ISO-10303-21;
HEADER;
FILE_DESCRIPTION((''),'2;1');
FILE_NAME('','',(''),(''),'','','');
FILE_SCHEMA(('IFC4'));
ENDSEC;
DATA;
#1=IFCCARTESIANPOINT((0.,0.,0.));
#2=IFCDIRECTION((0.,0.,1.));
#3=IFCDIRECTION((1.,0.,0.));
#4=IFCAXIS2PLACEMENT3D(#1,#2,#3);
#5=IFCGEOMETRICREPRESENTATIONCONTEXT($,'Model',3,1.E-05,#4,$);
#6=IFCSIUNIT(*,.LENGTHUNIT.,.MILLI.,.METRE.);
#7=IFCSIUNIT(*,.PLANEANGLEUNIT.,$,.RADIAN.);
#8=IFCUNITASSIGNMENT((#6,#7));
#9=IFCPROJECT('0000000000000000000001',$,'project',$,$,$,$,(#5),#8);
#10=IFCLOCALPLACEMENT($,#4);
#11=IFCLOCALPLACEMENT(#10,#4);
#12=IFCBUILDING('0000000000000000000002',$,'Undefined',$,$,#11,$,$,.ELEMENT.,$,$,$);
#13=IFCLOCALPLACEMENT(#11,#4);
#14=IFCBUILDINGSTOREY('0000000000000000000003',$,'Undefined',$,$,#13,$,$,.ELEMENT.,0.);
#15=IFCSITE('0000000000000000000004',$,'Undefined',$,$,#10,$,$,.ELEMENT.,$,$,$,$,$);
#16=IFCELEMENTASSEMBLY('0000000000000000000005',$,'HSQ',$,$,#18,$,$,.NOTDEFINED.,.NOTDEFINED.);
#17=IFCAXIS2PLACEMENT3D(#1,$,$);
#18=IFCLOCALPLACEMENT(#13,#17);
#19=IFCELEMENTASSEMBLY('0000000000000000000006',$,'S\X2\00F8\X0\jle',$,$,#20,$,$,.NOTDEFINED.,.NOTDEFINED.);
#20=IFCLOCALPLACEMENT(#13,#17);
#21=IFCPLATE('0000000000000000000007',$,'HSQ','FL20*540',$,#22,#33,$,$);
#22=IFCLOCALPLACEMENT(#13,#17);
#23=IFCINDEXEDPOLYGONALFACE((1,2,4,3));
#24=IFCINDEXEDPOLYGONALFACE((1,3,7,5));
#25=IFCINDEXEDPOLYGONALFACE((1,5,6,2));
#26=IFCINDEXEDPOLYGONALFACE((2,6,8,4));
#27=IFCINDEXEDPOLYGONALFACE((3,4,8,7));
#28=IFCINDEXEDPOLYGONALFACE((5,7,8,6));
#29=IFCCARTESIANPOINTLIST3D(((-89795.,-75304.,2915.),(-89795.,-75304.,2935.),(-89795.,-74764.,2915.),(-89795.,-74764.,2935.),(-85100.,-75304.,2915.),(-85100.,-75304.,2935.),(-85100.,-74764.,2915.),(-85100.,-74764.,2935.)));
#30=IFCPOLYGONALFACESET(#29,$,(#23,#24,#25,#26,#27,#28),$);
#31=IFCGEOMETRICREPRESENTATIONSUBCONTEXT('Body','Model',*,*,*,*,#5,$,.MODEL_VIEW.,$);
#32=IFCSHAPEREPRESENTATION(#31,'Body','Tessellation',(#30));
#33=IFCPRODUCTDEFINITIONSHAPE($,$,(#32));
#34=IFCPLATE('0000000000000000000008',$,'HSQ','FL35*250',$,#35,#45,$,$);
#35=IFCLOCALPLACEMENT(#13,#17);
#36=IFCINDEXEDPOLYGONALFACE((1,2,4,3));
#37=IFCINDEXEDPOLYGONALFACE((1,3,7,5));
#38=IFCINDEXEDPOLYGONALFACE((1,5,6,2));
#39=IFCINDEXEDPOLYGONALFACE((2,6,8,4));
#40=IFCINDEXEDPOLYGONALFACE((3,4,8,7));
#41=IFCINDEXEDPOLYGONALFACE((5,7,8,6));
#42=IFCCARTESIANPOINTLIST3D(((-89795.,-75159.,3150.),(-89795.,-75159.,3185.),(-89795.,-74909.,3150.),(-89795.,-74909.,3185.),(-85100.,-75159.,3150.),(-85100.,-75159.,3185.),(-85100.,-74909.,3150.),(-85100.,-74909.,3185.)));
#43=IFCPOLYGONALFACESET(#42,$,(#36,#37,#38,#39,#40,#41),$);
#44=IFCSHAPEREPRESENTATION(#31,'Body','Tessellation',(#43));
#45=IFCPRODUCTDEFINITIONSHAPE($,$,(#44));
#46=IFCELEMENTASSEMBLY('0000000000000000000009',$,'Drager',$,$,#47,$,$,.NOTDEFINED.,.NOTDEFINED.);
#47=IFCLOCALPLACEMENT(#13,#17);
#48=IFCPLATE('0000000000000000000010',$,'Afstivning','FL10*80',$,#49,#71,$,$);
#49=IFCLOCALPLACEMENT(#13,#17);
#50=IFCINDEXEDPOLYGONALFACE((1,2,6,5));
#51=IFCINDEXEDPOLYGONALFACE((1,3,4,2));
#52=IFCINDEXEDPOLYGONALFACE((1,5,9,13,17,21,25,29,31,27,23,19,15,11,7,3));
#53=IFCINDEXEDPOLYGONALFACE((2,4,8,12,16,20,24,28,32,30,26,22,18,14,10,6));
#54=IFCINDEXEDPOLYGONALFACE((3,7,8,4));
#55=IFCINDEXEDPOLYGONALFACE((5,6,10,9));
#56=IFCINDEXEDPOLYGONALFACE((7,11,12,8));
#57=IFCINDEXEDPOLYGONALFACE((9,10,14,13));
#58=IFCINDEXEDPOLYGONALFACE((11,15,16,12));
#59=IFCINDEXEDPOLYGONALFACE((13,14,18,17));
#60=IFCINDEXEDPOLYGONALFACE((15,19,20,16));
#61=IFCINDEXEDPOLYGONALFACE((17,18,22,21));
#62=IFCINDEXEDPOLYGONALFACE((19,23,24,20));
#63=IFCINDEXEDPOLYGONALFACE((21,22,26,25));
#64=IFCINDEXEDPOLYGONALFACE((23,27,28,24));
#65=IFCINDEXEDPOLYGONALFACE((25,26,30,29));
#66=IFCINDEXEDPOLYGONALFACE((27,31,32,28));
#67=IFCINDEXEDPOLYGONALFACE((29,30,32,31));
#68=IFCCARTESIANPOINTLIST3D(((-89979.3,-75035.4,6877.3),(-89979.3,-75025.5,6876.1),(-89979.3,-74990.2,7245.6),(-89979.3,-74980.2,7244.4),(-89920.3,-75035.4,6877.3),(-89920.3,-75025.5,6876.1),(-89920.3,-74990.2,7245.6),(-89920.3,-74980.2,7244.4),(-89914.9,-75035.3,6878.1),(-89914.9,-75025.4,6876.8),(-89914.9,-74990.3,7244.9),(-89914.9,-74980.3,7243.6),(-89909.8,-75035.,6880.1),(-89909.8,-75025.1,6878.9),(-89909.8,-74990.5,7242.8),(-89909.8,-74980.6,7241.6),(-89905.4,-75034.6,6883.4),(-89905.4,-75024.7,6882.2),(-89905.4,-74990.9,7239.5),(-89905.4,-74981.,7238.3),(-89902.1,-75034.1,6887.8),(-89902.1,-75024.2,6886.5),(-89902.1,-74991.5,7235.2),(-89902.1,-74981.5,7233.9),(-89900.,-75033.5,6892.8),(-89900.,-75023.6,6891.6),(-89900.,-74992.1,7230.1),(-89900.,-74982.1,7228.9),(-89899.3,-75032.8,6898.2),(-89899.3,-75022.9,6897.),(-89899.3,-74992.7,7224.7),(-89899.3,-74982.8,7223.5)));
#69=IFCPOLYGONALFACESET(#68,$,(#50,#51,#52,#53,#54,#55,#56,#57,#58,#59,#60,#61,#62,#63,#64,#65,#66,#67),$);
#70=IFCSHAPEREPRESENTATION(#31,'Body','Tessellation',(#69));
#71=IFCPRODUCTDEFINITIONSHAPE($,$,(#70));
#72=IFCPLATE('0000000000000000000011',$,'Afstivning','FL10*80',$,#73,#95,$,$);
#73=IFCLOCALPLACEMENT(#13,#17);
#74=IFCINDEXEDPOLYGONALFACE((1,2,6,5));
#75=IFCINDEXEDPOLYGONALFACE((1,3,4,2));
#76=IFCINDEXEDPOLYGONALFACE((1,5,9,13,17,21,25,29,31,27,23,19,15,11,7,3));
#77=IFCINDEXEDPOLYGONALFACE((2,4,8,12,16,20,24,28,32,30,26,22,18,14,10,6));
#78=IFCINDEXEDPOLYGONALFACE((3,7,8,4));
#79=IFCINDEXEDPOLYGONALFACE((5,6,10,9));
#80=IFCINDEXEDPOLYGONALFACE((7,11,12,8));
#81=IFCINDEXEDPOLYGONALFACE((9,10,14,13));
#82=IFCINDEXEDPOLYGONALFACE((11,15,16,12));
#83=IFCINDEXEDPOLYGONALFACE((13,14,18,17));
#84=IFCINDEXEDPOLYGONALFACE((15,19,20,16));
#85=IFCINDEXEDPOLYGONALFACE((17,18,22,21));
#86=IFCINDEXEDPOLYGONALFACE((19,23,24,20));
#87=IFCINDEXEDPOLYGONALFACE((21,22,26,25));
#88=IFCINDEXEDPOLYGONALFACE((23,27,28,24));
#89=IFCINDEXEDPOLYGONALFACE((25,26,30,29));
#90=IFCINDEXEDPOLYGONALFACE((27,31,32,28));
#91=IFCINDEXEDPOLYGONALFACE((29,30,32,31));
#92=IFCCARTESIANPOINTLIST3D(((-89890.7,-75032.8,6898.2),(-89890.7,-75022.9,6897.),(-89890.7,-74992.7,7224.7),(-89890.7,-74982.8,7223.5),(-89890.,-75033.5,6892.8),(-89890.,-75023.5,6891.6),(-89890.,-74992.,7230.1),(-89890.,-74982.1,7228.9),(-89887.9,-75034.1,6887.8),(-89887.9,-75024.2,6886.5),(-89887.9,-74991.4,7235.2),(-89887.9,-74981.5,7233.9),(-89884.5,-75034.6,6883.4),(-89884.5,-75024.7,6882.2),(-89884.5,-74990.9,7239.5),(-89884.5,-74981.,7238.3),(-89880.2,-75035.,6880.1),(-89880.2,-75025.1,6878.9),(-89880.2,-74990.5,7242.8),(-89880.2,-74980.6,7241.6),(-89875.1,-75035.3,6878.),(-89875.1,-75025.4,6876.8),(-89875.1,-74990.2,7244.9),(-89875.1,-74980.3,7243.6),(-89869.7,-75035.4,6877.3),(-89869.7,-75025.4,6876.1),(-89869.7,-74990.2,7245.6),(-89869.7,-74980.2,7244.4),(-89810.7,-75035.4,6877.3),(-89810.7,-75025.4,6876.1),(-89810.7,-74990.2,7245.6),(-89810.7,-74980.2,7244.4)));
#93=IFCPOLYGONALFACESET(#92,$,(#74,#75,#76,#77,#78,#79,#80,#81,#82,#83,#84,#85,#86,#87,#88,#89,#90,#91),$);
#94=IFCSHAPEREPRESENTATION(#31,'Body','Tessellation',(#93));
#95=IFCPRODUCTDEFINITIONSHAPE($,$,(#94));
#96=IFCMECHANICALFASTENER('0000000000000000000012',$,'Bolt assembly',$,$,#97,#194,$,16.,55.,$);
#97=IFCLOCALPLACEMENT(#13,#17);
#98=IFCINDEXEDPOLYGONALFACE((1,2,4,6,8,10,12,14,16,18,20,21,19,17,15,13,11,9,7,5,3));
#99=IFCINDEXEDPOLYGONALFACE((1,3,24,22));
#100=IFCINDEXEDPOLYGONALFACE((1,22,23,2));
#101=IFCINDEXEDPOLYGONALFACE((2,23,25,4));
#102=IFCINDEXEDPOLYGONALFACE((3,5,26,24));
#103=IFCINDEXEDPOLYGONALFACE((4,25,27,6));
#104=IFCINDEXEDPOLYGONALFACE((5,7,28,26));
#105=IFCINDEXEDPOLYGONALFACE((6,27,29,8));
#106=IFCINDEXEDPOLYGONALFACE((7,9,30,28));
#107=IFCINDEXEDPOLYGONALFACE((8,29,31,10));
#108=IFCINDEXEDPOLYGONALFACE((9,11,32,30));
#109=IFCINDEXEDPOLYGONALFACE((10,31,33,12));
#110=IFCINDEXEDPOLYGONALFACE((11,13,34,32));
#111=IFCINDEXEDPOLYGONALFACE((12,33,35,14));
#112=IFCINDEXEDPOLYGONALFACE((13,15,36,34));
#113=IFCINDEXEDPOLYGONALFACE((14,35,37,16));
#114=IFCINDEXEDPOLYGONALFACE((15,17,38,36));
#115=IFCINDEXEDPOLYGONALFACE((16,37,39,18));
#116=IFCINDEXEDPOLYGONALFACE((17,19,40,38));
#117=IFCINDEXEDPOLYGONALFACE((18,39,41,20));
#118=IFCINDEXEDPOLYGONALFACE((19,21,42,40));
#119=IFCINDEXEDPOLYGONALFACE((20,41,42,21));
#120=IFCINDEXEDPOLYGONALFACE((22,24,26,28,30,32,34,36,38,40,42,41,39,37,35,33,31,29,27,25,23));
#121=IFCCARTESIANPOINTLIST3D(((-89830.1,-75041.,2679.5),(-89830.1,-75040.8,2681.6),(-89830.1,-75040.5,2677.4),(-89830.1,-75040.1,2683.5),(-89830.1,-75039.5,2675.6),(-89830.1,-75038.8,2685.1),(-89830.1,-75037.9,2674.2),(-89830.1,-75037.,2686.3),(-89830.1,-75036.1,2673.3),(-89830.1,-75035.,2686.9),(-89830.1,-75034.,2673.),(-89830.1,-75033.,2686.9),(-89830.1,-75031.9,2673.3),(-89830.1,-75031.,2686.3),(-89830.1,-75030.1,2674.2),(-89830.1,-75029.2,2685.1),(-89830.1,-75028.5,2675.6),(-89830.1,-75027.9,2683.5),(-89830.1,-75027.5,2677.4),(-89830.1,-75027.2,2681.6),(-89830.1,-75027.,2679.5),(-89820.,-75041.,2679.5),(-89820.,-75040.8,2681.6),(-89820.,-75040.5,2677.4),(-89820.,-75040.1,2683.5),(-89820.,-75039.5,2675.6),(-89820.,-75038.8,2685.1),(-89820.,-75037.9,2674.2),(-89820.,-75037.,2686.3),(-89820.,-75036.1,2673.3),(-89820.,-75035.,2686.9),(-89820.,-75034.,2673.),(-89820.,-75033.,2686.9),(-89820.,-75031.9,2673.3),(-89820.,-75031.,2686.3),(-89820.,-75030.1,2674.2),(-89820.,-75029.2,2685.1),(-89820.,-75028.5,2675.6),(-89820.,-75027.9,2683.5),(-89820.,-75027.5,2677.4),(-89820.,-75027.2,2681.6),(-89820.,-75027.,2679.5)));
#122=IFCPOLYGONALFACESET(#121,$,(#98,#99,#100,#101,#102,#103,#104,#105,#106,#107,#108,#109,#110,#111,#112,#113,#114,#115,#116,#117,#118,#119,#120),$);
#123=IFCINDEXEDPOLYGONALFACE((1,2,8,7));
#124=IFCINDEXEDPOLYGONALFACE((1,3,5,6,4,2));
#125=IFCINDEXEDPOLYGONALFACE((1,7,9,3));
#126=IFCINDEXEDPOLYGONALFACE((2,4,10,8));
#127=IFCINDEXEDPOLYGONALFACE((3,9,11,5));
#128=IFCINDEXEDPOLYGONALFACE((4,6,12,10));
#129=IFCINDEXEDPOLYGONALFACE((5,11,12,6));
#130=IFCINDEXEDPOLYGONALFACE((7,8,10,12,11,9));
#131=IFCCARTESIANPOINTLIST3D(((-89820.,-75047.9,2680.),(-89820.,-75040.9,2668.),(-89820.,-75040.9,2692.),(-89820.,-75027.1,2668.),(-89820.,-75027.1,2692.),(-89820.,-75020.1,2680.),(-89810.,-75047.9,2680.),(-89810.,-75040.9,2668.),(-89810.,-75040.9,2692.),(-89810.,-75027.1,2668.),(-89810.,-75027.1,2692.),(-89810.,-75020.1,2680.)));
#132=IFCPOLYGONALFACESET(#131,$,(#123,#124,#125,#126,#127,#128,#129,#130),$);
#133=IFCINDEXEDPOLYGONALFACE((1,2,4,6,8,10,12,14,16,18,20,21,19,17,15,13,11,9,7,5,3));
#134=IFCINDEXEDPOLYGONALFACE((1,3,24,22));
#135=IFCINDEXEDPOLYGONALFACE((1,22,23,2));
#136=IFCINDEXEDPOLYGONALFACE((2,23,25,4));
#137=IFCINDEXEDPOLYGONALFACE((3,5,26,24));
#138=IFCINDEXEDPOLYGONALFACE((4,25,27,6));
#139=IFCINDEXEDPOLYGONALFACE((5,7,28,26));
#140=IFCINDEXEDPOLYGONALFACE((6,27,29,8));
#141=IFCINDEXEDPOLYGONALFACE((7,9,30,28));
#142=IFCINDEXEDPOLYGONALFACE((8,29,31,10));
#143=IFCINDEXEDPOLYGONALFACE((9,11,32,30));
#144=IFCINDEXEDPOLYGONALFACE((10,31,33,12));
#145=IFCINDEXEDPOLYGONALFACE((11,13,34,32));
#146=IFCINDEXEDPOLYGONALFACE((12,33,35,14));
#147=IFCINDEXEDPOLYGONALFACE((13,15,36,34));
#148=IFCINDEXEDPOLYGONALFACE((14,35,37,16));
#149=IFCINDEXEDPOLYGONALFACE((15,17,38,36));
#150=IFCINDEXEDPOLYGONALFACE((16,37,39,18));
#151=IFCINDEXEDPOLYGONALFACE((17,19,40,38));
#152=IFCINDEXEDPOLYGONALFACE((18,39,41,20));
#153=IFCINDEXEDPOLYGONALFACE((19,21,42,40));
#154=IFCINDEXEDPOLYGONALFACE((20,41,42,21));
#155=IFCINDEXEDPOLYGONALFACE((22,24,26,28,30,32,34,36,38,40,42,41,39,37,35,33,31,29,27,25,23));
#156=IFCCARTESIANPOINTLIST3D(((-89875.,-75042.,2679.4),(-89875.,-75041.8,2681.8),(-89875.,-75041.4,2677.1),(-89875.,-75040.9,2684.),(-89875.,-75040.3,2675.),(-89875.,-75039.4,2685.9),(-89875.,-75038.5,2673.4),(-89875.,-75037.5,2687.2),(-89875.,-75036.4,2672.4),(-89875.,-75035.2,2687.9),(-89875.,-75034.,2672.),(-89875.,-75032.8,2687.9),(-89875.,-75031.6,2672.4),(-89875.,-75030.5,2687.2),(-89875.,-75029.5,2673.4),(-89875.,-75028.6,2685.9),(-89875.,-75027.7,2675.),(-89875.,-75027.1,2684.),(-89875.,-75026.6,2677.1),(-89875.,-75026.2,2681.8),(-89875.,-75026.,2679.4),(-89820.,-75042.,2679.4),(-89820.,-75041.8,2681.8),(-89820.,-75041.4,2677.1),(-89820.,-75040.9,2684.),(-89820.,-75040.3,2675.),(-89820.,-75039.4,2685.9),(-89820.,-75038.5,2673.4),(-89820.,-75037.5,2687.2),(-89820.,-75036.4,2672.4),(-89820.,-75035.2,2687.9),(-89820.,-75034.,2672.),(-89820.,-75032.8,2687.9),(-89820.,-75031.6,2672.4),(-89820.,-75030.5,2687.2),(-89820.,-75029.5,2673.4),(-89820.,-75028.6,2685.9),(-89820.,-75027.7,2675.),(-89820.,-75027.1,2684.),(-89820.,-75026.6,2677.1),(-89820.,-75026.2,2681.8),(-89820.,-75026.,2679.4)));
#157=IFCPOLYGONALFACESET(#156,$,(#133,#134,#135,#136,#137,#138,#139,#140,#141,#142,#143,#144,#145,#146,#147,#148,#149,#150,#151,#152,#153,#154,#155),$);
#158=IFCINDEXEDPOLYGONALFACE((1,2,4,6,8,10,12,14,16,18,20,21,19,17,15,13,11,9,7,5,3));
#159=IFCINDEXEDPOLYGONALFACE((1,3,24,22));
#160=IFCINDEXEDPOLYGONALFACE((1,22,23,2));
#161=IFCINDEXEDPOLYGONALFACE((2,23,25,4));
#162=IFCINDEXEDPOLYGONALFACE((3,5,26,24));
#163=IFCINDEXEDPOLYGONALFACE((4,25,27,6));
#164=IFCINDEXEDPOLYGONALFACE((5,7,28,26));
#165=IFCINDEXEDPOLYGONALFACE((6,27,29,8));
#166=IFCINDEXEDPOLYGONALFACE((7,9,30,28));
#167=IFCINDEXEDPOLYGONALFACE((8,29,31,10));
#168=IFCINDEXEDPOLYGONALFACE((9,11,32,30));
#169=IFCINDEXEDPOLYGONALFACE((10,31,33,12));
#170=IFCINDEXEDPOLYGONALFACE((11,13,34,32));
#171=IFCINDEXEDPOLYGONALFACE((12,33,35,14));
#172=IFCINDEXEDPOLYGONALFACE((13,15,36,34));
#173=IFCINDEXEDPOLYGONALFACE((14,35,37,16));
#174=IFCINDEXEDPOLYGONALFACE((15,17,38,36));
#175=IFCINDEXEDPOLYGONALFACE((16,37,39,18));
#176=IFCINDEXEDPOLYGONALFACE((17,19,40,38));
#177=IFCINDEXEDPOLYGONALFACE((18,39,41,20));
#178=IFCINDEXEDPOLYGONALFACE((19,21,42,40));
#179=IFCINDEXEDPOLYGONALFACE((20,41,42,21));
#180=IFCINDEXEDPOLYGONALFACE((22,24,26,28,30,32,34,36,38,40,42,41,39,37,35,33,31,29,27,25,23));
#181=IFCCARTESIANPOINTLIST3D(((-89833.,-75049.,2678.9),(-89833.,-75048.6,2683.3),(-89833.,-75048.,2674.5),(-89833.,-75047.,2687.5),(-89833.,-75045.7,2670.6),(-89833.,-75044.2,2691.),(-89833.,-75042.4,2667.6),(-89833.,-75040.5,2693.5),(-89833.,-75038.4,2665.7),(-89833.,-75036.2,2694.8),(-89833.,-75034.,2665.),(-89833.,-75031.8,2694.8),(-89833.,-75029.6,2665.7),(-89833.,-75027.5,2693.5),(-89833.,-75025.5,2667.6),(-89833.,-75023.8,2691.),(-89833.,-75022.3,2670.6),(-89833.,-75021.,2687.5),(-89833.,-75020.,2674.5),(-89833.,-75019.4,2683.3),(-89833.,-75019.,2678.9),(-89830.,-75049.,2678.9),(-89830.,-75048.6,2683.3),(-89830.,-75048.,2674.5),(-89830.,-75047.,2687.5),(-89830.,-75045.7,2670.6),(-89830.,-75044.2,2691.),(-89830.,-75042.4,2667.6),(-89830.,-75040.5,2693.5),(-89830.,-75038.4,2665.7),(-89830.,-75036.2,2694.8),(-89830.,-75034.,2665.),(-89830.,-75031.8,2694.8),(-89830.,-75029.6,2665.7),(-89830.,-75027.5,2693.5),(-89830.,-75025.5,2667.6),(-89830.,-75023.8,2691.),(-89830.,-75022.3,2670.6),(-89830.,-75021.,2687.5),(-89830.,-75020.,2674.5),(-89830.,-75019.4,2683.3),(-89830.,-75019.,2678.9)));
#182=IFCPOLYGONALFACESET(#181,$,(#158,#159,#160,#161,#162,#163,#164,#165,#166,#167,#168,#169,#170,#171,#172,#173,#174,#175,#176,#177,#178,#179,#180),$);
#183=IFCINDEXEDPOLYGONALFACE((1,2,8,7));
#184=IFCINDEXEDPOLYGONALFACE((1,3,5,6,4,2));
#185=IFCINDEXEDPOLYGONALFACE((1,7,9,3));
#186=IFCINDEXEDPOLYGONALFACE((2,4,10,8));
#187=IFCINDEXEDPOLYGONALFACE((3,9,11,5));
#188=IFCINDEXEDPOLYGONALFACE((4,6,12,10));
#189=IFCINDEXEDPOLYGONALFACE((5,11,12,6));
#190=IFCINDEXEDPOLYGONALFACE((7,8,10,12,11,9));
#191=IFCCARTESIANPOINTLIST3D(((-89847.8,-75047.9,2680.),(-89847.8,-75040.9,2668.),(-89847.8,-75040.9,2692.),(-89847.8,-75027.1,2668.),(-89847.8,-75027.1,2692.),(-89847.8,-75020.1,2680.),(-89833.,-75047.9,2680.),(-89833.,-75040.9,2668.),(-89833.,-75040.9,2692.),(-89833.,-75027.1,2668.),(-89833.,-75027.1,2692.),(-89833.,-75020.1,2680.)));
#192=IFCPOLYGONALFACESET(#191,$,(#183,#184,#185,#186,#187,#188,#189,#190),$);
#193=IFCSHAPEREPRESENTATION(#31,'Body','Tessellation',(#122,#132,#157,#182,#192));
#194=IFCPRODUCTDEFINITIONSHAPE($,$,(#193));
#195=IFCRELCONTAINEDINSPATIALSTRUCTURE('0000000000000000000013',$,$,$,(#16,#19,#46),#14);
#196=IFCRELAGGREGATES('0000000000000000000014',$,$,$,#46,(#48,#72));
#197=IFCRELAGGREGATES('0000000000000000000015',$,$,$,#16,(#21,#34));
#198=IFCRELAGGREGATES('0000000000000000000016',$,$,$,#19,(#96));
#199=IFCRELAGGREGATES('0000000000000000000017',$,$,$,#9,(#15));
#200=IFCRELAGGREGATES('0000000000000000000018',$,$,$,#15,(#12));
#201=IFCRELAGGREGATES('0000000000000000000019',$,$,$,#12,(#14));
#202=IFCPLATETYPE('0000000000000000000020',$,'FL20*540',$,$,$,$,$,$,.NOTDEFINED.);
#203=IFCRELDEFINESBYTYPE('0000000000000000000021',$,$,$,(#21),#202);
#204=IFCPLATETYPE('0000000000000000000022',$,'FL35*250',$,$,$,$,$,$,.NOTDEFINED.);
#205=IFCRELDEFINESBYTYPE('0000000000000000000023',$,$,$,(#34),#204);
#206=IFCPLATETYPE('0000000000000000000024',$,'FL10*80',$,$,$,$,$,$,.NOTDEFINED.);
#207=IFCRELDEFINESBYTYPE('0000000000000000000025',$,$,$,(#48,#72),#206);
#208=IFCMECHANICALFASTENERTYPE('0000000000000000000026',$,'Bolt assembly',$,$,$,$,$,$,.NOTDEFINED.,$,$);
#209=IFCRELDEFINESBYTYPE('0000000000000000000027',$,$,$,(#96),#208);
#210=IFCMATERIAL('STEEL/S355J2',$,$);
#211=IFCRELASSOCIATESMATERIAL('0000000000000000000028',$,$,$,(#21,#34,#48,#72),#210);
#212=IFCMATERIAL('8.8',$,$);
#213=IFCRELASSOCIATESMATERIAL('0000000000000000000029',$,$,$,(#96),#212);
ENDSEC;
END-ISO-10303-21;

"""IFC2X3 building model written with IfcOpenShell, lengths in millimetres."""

from ifc_helpers import new_model, si_unit, frame, frame_2d, origin_with_axes, origin_2d_with_axis, place, context, subcontext, project, spatial, polyline, circle_curve, parameter, trimmed, segment, composite_curve, circle, outline, extrude, source, transform, mapped, material, type_object, element, aggregate, save


model = new_model("IFC2X3")

# Units and contexts
model_context = context("Model", 3, precision=1e-05, world=origin_with_axes())
body_context = subcontext(model_context, "Body", "Model", "MODEL_VIEW")
ifc_project = project(units=[si_unit("LENGTHUNIT", "METRE", prefix="MILLI"), si_unit("PLANEANGLEUNIT", "RADIAN")], contexts=[model_context])

# Site, building, storey
site_placement = place(None, origin_with_axes())
site = spatial("IfcSite", under=ifc_project, at=site_placement, Name="Undefined", CompositionType="ELEMENT")
building_placement = place(site_placement, origin_with_axes())
building = spatial("IfcBuilding", under=site, at=building_placement, Name="Undefined", CompositionType="ELEMENT")
storey_placement = place(building_placement, origin_with_axes())
storey = spatial("IfcBuildingStorey", under=building, at=storey_placement, Name="Undefined", CompositionType="ELEMENT", Elevation=0.0)

# Element assembly
assembly_1_placement = place(storey_placement, origin_with_axes())
assembly_1 = element("IfcElementAssembly", 1, at=assembly_1_placement, inside=storey, Name="HSQ", AssemblyPlace="NOTDEFINED", PredefinedType="NOTDEFINED")

# Element assembly
assembly_2_placement = place(storey_placement, origin_with_axes())
assembly_2 = element("IfcElementAssembly", 2, at=assembly_2_placement, inside=storey, Name="Søjle", AssemblyPlace="NOTDEFINED", PredefinedType="NOTDEFINED")

# Shared definitions
ifc_material_1 = material(Name="STEEL/S355J2")

# Plates
plate_type_1 = type_object("IfcPlateType", Name="FL20*540", PredefinedType="NOTDEFINED")
plate_1_placement = place(assembly_1_placement, frame((-89795.0, -75034.0, 2925.0), z_axis=(0.0, 0.0, 1.0), x_axis=(1.0, 0.0, 0.0)))
plate_1 = element("IfcPlate", 3, at=plate_1_placement, type_object=plate_type_1, material=ifc_material_1, Name="HSQ", Description="FL20*540", context=body_context, shape_type="SweptSolid", body=[
    extrude(outline(polyline([(0.0, -270.0), (0.0, 270.0), (4695.0, 270.0), (4695.0, -270.0), (0.0, -270.0)])), frame((0.0, 0.0, -10.0), z_axis=(0.0, 0.0, 1.0), x_axis=(1.0, 0.0, 0.0)), (0.0, 0.0, 1.0), 20.0),
])
plate_type_2 = type_object("IfcPlateType", Name="FL35*250", PredefinedType="NOTDEFINED")
plate_2_placement = place(assembly_1_placement, frame((-89795.0, -75034.0, 3167.5), z_axis=(0.0, 0.0, 1.0), x_axis=(1.0, 0.0, 0.0)))
plate_2 = element("IfcPlate", 4, at=plate_2_placement, type_object=plate_type_2, material=ifc_material_1, Name="HSQ", Description="FL35*250", context=body_context, shape_type="SweptSolid", body=[
    extrude(outline(polyline([(0.0, -125.0), (0.0, 125.0), (4695.0, 125.0), (4695.0, -125.0), (0.0, -125.0)])), frame((0.0, 0.0, -17.5), z_axis=(0.0, 0.0, 1.0), x_axis=(1.0, 0.0, 0.0)), (0.0, 0.0, 1.0), 35.0),
])

# Element assembly, plates
assembly_3_placement = place(storey_placement, origin_with_axes())
assembly_3 = element("IfcElementAssembly", 5, at=assembly_3_placement, inside=storey, Name="Drager", AssemblyPlace="NOTDEFINED", PredefinedType="NOTDEFINED")
plate_type_3 = type_object("IfcPlateType", Name="FL10*80", PredefinedType="NOTDEFINED")
plate_3_placement = place(assembly_3_placement, frame((-89899.3, -75030.4, 6876.7), z_axis=(0.0, 0.992546, -0.121869), x_axis=(-1.0, 0.0, 0.0)))
plate_3 = element("IfcPlate", 6, at=plate_3_placement, type_object=plate_type_3, material=ifc_material_1, Name="Afstivning", Description="FL10*80", context=body_context, shape_type="SweptSolid", body=[
    extrude(outline(composite_curve([segment(trimmed(circle_curve(frame_2d((21.0, 21.0), x_axis=(-1.0, 0.0)), 21.0), [parameter(0.0)], [parameter(1.570796)], True, "PARAMETER"), True, "CONTINUOUS"), segment(polyline([(21.0, 0.0), (80.0, 0.0), (80.0, 371.0), (21.0, 371.0)]), True, "CONTINUOUS"), segment(trimmed(circle_curve(frame_2d((21.0, 350.0), x_axis=(0.0, 1.0)), 21.0), [parameter(0.0)], [parameter(1.570796)], True, "PARAMETER"), True, "CONTINUOUS"), segment(polyline([(0.0, 350.0), (0.0, 21.0)]), True, "CONTINUOUS")], self_intersect=True)), frame((0.0, 0.0, -5.0), z_axis=(0.0, 0.0, 1.0), x_axis=(1.0, 0.0, 0.0)), (0.0, 0.0, 1.0), 10.0),
])
plate_4_placement = place(assembly_3_placement, frame((-89810.7, -75030.4, 6876.7), z_axis=(0.0, 0.992546, -0.121869), x_axis=(-1.0, 0.0, 0.0)))
plate_4 = element("IfcPlate", 7, at=plate_4_placement, type_object=plate_type_3, material=ifc_material_1, Name="Afstivning", Description="FL10*80", context=body_context, shape_type="SweptSolid", body=[
    extrude(outline(composite_curve([segment(polyline([(0.0, 0.0), (59.0, 0.0)]), True, "CONTINUOUS"), segment(trimmed(circle_curve(frame_2d((59.0, 21.0), x_axis=(0.0, -1.0)), 21.0), [parameter(0.0)], [parameter(1.570796)], True, "PARAMETER"), True, "CONTINUOUS"), segment(polyline([(80.0, 21.0), (80.0, 350.0)]), True, "CONTINUOUS"), segment(trimmed(circle_curve(frame_2d((59.0, 350.0), x_axis=(1.0, 0.0)), 21.0), [parameter(0.0)], [parameter(1.570796)], True, "PARAMETER"), True, "CONTINUOUS"), segment(polyline([(59.0, 371.0), (0.0, 371.0), (0.0, 0.0)]), True, "CONTINUOUS")], self_intersect=True)), frame((0.0, 0.0, -5.0), z_axis=(0.0, 0.0, 1.0), x_axis=(1.0, 0.0, 0.0)), (0.0, 0.0, 1.0), 10.0),
])
aggregate(assembly_3, [plate_3, plate_4])

# Mechanical fastener
ifc_material_2 = material(Name="8.8")
mechanical_fastener_type = type_object("IfcMechanicalFastenerType", Name="Bolt assembly")
shared_shape_1 = source(origin_with_axes(), body_context, "Body", "SweptSolid", [
    extrude(circle(Radius=7.0, at=origin_2d_with_axis()), frame((0.0, 0.0, 0.0), z_axis=(0.0, 1.0, 0.0), x_axis=(1.0, 0.0, 0.0)), (0.0, 0.0, 1.0), 10.1),
    extrude(outline(polyline([(12.0, -6.9), (12.0, 6.9), (0.0, 13.9), (-12.0, 6.9), (-12.0, -6.9), (0.0, -13.9), (12.0, -6.9)])), frame((0.0, -10.0, 0.0), z_axis=(0.0, 1.0, 0.0), x_axis=(1.0, 0.0, 0.0)), (0.0, 0.0, 1.0), 10.0),
    extrude(circle(Radius=8.0, at=origin_2d_with_axis()), frame((0.0, 0.0, 0.0), z_axis=(0.0, 1.0, 0.0), x_axis=(1.0, 0.0, 0.0)), (0.0, 0.0, 1.0), 55.0),
    extrude(circle(Radius=15.0, at=origin_2d_with_axis()), frame((0.0, 10.0, 0.0), z_axis=(0.0, 1.0, 0.0), x_axis=(1.0, 0.0, 0.0)), (0.0, 0.0, 1.0), 3.0),
    extrude(outline(polyline([(12.0, -6.9), (12.0, 6.9), (0.0, 13.9), (-12.0, 6.9), (-12.0, -6.9), (0.0, -13.9), (12.0, -6.9)])), frame((0.0, 13.0, 0.0), z_axis=(0.0, 1.0, 0.0), x_axis=(1.0, 0.0, 0.0)), (0.0, 0.0, 1.0), 14.8),
])
mechanical_fastener_1_placement = place(assembly_2_placement, frame((-89820.0, -75034.0, 2680.0), z_axis=(0.0, 1.0, 0.0), x_axis=(0.0, 0.0, -1.0)))
mechanical_fastener_1 = element("IfcMechanicalFastener", 8, at=mechanical_fastener_1_placement, type_object=mechanical_fastener_type, material=ifc_material_2, Name="Bolt assembly", NominalDiameter=16.0, NominalLength=55.0, context=body_context, shape_type="MappedRepresentation", body=[
    mapped(shared_shape_1, transform((0.0, 0.0, 0.0))),
])
aggregate(assembly_1, [plate_1, plate_2])
aggregate(assembly_2, [mechanical_fastener_1])

save(model, "model.ifc")
